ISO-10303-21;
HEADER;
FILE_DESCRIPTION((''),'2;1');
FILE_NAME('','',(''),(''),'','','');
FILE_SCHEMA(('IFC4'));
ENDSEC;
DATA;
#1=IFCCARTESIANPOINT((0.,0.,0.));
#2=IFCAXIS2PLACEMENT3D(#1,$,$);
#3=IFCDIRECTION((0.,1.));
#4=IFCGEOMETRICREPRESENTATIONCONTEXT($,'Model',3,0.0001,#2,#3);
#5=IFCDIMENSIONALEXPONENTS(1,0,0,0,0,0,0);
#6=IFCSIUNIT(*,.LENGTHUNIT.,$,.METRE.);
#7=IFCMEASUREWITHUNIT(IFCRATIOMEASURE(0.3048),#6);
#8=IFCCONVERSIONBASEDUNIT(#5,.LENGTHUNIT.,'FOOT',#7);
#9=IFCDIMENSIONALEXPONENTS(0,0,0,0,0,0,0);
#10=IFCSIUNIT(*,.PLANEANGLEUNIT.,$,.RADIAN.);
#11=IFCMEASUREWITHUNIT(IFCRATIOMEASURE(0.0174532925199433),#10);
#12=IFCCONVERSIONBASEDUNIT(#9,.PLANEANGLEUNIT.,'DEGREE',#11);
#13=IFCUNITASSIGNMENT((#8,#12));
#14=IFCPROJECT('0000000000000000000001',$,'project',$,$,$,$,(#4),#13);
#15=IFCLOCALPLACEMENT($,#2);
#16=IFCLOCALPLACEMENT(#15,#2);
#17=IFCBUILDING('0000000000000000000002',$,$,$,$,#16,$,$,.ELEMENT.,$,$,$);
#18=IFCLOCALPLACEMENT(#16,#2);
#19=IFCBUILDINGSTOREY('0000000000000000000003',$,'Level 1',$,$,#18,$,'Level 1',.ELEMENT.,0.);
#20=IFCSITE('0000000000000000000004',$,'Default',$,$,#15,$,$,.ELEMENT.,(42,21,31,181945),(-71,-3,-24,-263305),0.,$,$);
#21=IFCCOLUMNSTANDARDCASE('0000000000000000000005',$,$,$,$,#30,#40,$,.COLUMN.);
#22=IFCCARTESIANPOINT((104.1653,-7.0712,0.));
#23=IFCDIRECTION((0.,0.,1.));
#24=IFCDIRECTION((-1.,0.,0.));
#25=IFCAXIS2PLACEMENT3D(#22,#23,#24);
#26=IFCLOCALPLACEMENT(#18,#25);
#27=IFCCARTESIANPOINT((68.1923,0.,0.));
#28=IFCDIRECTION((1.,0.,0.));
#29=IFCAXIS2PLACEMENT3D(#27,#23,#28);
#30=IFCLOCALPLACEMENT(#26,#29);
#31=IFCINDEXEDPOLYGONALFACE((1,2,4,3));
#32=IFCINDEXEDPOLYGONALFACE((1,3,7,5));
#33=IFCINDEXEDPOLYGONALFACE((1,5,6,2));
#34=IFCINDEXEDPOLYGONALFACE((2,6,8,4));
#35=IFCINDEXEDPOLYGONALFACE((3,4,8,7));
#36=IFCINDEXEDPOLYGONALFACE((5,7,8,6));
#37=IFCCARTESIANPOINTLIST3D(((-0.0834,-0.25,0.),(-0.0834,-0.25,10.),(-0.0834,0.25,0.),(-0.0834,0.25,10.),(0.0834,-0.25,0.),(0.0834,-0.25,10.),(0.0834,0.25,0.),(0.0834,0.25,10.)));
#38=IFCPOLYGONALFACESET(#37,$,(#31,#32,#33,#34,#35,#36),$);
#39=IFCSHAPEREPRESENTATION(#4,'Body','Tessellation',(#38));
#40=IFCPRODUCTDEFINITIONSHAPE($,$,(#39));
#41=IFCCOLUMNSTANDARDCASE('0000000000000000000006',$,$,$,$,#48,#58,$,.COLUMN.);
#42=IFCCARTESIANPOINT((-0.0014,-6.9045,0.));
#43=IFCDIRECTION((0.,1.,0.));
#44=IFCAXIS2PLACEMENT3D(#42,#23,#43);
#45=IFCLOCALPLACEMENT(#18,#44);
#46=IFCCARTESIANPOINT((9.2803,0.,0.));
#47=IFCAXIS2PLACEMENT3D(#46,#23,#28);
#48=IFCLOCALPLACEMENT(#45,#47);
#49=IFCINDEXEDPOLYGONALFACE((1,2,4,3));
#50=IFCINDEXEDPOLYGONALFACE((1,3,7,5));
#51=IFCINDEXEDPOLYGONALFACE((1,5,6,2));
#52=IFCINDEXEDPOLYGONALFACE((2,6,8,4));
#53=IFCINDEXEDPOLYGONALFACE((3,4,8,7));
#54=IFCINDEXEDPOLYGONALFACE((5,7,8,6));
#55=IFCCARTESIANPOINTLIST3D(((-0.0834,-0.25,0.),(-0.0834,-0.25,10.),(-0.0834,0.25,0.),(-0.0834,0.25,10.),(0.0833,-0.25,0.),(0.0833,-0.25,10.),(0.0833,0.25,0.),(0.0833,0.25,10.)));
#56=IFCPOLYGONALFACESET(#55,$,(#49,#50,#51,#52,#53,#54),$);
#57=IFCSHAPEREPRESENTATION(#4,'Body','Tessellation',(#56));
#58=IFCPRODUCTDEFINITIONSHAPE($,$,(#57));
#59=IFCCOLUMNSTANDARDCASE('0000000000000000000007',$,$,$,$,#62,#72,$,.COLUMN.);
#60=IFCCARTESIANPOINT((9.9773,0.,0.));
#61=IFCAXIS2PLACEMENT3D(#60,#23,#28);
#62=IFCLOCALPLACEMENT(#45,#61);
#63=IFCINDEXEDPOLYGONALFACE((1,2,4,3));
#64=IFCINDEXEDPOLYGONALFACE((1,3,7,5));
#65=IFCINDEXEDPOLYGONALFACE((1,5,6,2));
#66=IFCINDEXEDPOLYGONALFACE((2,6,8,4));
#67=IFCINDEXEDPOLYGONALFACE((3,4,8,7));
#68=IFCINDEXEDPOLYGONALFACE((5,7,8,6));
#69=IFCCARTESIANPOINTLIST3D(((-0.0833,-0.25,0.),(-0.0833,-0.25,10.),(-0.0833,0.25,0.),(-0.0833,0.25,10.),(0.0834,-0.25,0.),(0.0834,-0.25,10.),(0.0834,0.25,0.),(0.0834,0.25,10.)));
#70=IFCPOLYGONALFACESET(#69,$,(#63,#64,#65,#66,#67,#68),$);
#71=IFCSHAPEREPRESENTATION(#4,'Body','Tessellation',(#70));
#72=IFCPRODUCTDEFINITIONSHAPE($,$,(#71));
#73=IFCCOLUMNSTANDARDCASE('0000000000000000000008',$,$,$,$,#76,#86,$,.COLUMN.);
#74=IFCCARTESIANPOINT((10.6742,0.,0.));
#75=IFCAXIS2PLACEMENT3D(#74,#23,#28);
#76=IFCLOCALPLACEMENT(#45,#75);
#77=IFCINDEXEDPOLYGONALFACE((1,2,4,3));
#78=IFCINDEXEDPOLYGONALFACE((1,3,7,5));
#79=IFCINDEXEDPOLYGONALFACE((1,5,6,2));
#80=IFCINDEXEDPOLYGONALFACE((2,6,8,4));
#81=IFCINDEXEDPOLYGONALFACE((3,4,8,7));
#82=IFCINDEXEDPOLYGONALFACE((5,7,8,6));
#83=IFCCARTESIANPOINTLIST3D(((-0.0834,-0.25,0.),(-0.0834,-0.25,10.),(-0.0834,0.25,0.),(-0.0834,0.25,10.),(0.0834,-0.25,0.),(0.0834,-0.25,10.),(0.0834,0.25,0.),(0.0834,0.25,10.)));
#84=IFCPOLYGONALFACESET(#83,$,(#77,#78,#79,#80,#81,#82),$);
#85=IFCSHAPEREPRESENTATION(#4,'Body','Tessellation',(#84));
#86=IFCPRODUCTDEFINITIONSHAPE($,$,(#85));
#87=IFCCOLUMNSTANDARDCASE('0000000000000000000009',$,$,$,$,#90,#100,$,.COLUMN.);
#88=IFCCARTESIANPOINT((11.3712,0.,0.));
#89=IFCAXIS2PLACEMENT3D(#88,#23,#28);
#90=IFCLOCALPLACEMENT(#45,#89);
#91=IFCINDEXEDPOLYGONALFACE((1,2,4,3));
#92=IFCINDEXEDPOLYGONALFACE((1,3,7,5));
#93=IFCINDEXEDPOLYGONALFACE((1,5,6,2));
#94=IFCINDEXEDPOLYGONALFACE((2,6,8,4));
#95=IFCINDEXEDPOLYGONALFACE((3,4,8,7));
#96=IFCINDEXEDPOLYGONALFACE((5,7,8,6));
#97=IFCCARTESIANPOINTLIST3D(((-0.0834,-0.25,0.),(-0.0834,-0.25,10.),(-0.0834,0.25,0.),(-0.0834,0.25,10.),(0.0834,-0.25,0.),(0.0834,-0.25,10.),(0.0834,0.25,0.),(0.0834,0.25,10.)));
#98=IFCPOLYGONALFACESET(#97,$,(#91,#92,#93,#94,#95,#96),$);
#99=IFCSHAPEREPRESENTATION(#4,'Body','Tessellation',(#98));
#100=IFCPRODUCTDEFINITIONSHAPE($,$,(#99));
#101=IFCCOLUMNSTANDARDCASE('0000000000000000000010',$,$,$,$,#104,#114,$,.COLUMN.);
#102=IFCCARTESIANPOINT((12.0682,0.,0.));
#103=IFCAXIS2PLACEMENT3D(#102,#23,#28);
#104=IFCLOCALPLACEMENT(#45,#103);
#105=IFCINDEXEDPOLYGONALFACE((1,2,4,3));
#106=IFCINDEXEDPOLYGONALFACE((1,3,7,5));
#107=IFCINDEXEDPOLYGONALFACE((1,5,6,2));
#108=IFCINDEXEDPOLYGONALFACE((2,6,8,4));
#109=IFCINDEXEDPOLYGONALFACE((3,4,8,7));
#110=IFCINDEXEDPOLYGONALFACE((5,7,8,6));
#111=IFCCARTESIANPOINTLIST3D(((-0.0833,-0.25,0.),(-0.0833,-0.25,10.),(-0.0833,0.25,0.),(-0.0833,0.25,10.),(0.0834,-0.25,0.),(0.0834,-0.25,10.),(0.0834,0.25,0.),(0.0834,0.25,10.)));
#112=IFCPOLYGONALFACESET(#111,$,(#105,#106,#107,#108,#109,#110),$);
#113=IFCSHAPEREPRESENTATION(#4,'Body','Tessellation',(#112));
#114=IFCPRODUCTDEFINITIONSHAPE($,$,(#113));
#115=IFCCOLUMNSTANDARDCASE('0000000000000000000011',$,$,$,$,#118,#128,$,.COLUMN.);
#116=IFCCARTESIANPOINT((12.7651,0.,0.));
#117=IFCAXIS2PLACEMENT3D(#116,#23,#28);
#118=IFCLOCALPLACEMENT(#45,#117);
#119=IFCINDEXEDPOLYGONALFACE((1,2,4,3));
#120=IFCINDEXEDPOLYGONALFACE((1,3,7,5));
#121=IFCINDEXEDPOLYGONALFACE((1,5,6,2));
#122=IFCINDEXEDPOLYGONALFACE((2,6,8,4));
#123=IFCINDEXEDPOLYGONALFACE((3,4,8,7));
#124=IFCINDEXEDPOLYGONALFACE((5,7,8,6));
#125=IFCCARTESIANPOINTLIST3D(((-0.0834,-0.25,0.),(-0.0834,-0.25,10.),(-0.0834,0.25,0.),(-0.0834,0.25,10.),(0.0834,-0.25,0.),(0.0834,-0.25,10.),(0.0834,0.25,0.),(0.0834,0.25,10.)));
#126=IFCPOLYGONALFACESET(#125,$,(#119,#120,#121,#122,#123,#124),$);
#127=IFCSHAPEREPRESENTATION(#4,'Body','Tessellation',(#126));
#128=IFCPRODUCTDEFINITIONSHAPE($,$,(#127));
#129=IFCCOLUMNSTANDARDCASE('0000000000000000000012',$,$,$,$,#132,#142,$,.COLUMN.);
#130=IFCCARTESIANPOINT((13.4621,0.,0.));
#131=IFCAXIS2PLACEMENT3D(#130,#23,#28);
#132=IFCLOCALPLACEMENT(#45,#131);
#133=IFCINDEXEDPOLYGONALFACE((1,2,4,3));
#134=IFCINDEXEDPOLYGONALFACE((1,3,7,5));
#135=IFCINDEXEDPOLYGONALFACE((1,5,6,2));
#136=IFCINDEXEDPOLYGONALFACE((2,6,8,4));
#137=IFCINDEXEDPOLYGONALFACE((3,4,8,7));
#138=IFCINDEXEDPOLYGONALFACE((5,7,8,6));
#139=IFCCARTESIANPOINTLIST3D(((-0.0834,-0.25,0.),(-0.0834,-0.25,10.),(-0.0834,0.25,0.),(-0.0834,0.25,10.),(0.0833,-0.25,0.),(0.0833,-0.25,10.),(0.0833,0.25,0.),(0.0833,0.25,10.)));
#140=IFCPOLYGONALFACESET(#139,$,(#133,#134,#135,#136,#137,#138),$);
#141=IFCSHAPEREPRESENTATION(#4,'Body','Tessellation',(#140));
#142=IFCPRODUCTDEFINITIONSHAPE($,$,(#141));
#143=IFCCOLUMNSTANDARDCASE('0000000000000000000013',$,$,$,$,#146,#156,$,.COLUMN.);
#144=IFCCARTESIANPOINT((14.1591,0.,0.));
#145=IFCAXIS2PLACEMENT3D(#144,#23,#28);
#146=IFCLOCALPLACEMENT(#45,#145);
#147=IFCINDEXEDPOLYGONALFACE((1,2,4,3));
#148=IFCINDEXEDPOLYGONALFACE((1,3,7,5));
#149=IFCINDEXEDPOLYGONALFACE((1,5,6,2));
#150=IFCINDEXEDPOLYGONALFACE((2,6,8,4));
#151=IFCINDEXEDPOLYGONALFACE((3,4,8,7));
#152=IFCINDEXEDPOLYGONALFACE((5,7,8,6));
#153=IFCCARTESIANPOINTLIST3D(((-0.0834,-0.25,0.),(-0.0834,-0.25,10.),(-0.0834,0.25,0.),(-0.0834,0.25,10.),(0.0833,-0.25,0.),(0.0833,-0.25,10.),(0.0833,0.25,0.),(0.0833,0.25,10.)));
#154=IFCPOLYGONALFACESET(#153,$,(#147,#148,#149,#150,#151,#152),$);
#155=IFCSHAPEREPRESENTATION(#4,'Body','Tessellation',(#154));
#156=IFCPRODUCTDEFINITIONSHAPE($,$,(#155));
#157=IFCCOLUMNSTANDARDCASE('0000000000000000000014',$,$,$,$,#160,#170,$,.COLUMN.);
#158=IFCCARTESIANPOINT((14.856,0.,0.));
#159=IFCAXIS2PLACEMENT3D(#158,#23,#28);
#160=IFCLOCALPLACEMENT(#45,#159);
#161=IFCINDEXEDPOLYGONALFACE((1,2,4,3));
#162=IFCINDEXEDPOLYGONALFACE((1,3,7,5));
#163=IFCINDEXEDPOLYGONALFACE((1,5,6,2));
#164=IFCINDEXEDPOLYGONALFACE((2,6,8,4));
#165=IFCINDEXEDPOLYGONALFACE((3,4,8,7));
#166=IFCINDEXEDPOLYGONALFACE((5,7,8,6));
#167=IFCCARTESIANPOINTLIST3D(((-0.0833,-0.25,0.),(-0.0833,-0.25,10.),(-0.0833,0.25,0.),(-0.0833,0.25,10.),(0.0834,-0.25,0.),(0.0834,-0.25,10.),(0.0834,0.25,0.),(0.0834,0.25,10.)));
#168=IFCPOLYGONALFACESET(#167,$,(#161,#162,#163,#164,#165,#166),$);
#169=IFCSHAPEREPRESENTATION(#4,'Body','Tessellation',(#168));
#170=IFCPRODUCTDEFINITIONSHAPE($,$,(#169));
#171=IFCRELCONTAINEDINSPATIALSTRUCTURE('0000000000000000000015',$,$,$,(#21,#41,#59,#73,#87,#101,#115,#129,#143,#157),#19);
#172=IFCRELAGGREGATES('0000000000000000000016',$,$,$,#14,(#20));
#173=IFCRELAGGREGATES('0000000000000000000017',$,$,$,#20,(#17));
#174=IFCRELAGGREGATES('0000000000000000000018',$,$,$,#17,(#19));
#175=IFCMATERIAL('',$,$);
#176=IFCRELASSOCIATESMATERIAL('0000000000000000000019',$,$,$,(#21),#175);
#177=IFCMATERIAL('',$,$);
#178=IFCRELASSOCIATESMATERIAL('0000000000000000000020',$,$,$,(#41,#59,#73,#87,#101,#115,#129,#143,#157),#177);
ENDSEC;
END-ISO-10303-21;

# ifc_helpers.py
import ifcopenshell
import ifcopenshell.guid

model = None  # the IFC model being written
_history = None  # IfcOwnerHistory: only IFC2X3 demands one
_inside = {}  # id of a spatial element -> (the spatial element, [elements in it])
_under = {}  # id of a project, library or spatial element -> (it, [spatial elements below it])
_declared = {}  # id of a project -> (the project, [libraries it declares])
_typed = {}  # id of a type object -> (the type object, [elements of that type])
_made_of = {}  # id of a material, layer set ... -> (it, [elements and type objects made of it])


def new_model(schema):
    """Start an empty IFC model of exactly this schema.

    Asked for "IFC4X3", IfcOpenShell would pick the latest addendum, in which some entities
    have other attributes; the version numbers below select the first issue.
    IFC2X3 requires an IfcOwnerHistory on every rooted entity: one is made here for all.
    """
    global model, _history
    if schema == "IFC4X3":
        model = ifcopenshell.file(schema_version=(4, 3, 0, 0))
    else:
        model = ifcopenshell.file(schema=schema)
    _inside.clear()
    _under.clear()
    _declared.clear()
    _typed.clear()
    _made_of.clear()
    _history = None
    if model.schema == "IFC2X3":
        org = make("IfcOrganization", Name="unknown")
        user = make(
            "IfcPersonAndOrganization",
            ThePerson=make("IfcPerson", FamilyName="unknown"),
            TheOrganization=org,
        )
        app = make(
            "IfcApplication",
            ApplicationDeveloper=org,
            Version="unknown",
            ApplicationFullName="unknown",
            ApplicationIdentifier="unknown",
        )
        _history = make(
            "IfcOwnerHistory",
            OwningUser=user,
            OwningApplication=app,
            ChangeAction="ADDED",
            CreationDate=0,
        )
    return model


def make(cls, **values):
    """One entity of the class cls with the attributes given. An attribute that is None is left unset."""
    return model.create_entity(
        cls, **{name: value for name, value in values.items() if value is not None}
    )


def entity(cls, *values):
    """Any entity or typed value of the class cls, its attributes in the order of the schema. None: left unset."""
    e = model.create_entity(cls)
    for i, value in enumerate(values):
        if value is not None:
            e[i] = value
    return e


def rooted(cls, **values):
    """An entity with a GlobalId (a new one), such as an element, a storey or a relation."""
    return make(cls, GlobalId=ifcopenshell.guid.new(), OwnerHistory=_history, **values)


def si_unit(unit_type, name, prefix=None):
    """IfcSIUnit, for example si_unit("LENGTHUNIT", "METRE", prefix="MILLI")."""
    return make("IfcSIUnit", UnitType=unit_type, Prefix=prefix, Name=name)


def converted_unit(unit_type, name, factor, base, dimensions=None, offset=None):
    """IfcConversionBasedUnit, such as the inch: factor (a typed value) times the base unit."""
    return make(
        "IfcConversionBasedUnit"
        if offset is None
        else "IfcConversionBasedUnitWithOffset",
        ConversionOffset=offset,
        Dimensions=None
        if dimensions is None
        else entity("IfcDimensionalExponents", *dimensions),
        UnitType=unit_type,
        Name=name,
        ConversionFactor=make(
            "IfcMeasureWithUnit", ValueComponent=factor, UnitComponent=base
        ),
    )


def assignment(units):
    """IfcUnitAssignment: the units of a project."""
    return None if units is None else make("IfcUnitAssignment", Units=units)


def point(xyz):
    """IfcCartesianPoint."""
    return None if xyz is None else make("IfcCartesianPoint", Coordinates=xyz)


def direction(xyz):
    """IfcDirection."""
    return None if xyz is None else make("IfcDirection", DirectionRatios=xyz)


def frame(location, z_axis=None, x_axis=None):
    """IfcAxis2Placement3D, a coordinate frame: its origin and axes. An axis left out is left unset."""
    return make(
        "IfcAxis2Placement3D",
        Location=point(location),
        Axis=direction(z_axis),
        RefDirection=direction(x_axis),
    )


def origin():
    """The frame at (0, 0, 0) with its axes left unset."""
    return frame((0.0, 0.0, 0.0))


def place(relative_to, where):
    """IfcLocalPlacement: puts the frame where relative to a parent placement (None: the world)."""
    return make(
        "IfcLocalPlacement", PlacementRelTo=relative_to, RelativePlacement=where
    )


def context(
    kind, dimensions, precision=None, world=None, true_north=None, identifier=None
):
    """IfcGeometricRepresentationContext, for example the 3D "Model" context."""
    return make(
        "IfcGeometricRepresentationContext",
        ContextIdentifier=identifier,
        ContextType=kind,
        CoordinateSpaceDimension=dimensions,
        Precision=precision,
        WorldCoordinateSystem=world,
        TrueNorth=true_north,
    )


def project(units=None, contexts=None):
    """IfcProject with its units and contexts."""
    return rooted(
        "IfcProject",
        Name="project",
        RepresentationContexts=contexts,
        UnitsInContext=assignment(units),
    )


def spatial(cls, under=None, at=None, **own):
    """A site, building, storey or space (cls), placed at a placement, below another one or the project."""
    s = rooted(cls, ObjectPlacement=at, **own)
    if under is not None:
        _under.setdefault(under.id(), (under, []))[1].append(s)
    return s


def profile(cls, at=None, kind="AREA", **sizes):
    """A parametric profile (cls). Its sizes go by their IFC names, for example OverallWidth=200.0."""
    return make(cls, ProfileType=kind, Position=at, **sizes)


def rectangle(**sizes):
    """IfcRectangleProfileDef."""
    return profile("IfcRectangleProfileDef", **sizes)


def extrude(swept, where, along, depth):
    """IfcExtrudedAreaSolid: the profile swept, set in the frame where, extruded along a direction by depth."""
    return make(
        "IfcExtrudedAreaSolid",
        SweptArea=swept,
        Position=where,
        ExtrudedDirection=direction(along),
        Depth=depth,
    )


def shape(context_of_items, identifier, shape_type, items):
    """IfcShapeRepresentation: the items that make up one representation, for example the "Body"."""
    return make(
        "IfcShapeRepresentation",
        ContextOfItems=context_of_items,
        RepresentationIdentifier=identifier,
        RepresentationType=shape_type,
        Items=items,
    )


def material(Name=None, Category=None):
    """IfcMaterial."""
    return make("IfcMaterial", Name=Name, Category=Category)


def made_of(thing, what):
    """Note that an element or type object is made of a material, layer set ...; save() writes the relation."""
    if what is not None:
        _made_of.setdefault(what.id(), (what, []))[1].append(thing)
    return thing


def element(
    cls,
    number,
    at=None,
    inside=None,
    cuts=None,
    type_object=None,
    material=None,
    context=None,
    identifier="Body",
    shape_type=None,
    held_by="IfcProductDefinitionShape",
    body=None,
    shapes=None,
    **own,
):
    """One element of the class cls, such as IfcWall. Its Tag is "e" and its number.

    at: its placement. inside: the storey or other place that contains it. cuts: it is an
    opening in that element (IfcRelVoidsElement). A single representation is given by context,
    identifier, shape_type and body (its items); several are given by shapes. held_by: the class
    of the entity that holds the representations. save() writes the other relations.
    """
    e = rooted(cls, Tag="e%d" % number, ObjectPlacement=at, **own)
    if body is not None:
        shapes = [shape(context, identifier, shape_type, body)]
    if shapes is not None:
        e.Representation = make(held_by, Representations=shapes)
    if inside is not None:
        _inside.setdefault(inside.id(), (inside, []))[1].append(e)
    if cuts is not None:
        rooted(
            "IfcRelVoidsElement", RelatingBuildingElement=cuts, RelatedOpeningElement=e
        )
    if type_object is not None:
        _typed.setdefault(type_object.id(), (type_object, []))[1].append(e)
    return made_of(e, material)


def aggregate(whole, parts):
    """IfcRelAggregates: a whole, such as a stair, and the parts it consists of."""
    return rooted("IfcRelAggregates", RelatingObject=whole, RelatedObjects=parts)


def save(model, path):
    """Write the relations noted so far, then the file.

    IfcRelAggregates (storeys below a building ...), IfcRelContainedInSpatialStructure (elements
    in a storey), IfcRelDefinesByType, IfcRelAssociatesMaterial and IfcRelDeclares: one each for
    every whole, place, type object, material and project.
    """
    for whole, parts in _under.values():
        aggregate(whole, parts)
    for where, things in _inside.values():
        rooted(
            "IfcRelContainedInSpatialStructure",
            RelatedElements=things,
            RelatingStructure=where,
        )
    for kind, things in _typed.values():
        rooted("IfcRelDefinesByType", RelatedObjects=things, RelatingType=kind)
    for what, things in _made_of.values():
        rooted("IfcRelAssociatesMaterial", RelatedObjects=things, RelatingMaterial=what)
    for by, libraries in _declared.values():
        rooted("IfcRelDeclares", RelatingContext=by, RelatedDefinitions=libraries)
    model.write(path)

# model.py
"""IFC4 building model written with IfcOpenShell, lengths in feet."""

from ifc_helpers import new_model, entity, si_unit, converted_unit, direction, frame, origin, place, context, project, spatial, rectangle, extrude, material, element, save


model = new_model("IFC4")

# Units and contexts
model_context = context("Model", 3, precision=0.0001, world=origin(), true_north=direction((0.0, 1.0)))
ifc_project = project(units=[converted_unit("LENGTHUNIT", "FOOT", entity("IfcRatioMeasure", 0.3048), si_unit("LENGTHUNIT", "METRE"), dimensions=[1, 0, 0, 0, 0, 0, 0]), converted_unit("PLANEANGLEUNIT", "DEGREE", entity("IfcRatioMeasure", 0.0174532925199433), si_unit("PLANEANGLEUNIT", "RADIAN"), dimensions=[0, 0, 0, 0, 0, 0, 0])], contexts=[model_context])

# Site, building, storey
site_placement = place(None, origin())
site = spatial("IfcSite", under=ifc_project, at=site_placement, Name="Default", CompositionType="ELEMENT", RefLatitude=(42, 21, 31, 181945), RefLongitude=(-71, -3, -24, -263305), RefElevation=0.0)
building_placement = place(site_placement, origin())
building = spatial("IfcBuilding", under=site, at=building_placement, CompositionType="ELEMENT")
storey_placement = place(building_placement, origin())
storey = spatial("IfcBuildingStorey", under=building, at=storey_placement, Name="Level 1", LongName="Level 1", CompositionType="ELEMENT", Elevation=0.0)

# Columns
ifc_material_1 = material(Name="")
placement_1 = place(storey_placement, frame((104.1653, -7.0712, 0.0), z_axis=(0.0, 0.0, 1.0), x_axis=(-1.0, 0.0, 0.0)))
for number, where, z_axis, x_axis in (
    (1, (68.1923, 0.0, 0.0), (0.0, 0.0, 1.0), (1.0, 0.0, 0.0)),
):
    element("IfcColumnStandardCase", number, at=place(placement_1, frame(where, z_axis=z_axis, x_axis=x_axis)), inside=storey, material=ifc_material_1, PredefinedType="COLUMN", context=model_context, shape_type="SweptSolid", body=[
        extrude(rectangle(XDim=0.1667, YDim=0.5), origin(), (0.0, 0.0, 1.0), 10.0),
    ])
ifc_material_2 = material(Name="")
placement_2 = place(storey_placement, frame((-0.0014, -6.9045, 0.0), z_axis=(0.0, 0.0, 1.0), x_axis=(0.0, 1.0, 0.0)))
for number, where, z_axis, x_axis in (
    (2, (9.2803, 0.0, 0.0), (0.0, 0.0, 1.0), (1.0, 0.0, 0.0)),
    (3, (9.9773, 0.0, 0.0), (0.0, 0.0, 1.0), (1.0, 0.0, 0.0)),
    (4, (10.6742, 0.0, 0.0), (0.0, 0.0, 1.0), (1.0, 0.0, 0.0)),
    (5, (11.3712, 0.0, 0.0), (0.0, 0.0, 1.0), (1.0, 0.0, 0.0)),
    (6, (12.0682, 0.0, 0.0), (0.0, 0.0, 1.0), (1.0, 0.0, 0.0)),
    (7, (12.7651, 0.0, 0.0), (0.0, 0.0, 1.0), (1.0, 0.0, 0.0)),
    (8, (13.4621, 0.0, 0.0), (0.0, 0.0, 1.0), (1.0, 0.0, 0.0)),
    (9, (14.1591, 0.0, 0.0), (0.0, 0.0, 1.0), (1.0, 0.0, 0.0)),
    (10, (14.856, 0.0, 0.0), (0.0, 0.0, 1.0), (1.0, 0.0, 0.0)),
):
    element("IfcColumnStandardCase", number, at=place(placement_2, frame(where, z_axis=z_axis, x_axis=x_axis)), inside=storey, material=ifc_material_2, PredefinedType="COLUMN", context=model_context, shape_type="SweptSolid", body=[
        extrude(rectangle(XDim=0.1667, YDim=0.5), origin(), (0.0, 0.0, 1.0), 10.0),
    ])

save(model, "model.ifc")
